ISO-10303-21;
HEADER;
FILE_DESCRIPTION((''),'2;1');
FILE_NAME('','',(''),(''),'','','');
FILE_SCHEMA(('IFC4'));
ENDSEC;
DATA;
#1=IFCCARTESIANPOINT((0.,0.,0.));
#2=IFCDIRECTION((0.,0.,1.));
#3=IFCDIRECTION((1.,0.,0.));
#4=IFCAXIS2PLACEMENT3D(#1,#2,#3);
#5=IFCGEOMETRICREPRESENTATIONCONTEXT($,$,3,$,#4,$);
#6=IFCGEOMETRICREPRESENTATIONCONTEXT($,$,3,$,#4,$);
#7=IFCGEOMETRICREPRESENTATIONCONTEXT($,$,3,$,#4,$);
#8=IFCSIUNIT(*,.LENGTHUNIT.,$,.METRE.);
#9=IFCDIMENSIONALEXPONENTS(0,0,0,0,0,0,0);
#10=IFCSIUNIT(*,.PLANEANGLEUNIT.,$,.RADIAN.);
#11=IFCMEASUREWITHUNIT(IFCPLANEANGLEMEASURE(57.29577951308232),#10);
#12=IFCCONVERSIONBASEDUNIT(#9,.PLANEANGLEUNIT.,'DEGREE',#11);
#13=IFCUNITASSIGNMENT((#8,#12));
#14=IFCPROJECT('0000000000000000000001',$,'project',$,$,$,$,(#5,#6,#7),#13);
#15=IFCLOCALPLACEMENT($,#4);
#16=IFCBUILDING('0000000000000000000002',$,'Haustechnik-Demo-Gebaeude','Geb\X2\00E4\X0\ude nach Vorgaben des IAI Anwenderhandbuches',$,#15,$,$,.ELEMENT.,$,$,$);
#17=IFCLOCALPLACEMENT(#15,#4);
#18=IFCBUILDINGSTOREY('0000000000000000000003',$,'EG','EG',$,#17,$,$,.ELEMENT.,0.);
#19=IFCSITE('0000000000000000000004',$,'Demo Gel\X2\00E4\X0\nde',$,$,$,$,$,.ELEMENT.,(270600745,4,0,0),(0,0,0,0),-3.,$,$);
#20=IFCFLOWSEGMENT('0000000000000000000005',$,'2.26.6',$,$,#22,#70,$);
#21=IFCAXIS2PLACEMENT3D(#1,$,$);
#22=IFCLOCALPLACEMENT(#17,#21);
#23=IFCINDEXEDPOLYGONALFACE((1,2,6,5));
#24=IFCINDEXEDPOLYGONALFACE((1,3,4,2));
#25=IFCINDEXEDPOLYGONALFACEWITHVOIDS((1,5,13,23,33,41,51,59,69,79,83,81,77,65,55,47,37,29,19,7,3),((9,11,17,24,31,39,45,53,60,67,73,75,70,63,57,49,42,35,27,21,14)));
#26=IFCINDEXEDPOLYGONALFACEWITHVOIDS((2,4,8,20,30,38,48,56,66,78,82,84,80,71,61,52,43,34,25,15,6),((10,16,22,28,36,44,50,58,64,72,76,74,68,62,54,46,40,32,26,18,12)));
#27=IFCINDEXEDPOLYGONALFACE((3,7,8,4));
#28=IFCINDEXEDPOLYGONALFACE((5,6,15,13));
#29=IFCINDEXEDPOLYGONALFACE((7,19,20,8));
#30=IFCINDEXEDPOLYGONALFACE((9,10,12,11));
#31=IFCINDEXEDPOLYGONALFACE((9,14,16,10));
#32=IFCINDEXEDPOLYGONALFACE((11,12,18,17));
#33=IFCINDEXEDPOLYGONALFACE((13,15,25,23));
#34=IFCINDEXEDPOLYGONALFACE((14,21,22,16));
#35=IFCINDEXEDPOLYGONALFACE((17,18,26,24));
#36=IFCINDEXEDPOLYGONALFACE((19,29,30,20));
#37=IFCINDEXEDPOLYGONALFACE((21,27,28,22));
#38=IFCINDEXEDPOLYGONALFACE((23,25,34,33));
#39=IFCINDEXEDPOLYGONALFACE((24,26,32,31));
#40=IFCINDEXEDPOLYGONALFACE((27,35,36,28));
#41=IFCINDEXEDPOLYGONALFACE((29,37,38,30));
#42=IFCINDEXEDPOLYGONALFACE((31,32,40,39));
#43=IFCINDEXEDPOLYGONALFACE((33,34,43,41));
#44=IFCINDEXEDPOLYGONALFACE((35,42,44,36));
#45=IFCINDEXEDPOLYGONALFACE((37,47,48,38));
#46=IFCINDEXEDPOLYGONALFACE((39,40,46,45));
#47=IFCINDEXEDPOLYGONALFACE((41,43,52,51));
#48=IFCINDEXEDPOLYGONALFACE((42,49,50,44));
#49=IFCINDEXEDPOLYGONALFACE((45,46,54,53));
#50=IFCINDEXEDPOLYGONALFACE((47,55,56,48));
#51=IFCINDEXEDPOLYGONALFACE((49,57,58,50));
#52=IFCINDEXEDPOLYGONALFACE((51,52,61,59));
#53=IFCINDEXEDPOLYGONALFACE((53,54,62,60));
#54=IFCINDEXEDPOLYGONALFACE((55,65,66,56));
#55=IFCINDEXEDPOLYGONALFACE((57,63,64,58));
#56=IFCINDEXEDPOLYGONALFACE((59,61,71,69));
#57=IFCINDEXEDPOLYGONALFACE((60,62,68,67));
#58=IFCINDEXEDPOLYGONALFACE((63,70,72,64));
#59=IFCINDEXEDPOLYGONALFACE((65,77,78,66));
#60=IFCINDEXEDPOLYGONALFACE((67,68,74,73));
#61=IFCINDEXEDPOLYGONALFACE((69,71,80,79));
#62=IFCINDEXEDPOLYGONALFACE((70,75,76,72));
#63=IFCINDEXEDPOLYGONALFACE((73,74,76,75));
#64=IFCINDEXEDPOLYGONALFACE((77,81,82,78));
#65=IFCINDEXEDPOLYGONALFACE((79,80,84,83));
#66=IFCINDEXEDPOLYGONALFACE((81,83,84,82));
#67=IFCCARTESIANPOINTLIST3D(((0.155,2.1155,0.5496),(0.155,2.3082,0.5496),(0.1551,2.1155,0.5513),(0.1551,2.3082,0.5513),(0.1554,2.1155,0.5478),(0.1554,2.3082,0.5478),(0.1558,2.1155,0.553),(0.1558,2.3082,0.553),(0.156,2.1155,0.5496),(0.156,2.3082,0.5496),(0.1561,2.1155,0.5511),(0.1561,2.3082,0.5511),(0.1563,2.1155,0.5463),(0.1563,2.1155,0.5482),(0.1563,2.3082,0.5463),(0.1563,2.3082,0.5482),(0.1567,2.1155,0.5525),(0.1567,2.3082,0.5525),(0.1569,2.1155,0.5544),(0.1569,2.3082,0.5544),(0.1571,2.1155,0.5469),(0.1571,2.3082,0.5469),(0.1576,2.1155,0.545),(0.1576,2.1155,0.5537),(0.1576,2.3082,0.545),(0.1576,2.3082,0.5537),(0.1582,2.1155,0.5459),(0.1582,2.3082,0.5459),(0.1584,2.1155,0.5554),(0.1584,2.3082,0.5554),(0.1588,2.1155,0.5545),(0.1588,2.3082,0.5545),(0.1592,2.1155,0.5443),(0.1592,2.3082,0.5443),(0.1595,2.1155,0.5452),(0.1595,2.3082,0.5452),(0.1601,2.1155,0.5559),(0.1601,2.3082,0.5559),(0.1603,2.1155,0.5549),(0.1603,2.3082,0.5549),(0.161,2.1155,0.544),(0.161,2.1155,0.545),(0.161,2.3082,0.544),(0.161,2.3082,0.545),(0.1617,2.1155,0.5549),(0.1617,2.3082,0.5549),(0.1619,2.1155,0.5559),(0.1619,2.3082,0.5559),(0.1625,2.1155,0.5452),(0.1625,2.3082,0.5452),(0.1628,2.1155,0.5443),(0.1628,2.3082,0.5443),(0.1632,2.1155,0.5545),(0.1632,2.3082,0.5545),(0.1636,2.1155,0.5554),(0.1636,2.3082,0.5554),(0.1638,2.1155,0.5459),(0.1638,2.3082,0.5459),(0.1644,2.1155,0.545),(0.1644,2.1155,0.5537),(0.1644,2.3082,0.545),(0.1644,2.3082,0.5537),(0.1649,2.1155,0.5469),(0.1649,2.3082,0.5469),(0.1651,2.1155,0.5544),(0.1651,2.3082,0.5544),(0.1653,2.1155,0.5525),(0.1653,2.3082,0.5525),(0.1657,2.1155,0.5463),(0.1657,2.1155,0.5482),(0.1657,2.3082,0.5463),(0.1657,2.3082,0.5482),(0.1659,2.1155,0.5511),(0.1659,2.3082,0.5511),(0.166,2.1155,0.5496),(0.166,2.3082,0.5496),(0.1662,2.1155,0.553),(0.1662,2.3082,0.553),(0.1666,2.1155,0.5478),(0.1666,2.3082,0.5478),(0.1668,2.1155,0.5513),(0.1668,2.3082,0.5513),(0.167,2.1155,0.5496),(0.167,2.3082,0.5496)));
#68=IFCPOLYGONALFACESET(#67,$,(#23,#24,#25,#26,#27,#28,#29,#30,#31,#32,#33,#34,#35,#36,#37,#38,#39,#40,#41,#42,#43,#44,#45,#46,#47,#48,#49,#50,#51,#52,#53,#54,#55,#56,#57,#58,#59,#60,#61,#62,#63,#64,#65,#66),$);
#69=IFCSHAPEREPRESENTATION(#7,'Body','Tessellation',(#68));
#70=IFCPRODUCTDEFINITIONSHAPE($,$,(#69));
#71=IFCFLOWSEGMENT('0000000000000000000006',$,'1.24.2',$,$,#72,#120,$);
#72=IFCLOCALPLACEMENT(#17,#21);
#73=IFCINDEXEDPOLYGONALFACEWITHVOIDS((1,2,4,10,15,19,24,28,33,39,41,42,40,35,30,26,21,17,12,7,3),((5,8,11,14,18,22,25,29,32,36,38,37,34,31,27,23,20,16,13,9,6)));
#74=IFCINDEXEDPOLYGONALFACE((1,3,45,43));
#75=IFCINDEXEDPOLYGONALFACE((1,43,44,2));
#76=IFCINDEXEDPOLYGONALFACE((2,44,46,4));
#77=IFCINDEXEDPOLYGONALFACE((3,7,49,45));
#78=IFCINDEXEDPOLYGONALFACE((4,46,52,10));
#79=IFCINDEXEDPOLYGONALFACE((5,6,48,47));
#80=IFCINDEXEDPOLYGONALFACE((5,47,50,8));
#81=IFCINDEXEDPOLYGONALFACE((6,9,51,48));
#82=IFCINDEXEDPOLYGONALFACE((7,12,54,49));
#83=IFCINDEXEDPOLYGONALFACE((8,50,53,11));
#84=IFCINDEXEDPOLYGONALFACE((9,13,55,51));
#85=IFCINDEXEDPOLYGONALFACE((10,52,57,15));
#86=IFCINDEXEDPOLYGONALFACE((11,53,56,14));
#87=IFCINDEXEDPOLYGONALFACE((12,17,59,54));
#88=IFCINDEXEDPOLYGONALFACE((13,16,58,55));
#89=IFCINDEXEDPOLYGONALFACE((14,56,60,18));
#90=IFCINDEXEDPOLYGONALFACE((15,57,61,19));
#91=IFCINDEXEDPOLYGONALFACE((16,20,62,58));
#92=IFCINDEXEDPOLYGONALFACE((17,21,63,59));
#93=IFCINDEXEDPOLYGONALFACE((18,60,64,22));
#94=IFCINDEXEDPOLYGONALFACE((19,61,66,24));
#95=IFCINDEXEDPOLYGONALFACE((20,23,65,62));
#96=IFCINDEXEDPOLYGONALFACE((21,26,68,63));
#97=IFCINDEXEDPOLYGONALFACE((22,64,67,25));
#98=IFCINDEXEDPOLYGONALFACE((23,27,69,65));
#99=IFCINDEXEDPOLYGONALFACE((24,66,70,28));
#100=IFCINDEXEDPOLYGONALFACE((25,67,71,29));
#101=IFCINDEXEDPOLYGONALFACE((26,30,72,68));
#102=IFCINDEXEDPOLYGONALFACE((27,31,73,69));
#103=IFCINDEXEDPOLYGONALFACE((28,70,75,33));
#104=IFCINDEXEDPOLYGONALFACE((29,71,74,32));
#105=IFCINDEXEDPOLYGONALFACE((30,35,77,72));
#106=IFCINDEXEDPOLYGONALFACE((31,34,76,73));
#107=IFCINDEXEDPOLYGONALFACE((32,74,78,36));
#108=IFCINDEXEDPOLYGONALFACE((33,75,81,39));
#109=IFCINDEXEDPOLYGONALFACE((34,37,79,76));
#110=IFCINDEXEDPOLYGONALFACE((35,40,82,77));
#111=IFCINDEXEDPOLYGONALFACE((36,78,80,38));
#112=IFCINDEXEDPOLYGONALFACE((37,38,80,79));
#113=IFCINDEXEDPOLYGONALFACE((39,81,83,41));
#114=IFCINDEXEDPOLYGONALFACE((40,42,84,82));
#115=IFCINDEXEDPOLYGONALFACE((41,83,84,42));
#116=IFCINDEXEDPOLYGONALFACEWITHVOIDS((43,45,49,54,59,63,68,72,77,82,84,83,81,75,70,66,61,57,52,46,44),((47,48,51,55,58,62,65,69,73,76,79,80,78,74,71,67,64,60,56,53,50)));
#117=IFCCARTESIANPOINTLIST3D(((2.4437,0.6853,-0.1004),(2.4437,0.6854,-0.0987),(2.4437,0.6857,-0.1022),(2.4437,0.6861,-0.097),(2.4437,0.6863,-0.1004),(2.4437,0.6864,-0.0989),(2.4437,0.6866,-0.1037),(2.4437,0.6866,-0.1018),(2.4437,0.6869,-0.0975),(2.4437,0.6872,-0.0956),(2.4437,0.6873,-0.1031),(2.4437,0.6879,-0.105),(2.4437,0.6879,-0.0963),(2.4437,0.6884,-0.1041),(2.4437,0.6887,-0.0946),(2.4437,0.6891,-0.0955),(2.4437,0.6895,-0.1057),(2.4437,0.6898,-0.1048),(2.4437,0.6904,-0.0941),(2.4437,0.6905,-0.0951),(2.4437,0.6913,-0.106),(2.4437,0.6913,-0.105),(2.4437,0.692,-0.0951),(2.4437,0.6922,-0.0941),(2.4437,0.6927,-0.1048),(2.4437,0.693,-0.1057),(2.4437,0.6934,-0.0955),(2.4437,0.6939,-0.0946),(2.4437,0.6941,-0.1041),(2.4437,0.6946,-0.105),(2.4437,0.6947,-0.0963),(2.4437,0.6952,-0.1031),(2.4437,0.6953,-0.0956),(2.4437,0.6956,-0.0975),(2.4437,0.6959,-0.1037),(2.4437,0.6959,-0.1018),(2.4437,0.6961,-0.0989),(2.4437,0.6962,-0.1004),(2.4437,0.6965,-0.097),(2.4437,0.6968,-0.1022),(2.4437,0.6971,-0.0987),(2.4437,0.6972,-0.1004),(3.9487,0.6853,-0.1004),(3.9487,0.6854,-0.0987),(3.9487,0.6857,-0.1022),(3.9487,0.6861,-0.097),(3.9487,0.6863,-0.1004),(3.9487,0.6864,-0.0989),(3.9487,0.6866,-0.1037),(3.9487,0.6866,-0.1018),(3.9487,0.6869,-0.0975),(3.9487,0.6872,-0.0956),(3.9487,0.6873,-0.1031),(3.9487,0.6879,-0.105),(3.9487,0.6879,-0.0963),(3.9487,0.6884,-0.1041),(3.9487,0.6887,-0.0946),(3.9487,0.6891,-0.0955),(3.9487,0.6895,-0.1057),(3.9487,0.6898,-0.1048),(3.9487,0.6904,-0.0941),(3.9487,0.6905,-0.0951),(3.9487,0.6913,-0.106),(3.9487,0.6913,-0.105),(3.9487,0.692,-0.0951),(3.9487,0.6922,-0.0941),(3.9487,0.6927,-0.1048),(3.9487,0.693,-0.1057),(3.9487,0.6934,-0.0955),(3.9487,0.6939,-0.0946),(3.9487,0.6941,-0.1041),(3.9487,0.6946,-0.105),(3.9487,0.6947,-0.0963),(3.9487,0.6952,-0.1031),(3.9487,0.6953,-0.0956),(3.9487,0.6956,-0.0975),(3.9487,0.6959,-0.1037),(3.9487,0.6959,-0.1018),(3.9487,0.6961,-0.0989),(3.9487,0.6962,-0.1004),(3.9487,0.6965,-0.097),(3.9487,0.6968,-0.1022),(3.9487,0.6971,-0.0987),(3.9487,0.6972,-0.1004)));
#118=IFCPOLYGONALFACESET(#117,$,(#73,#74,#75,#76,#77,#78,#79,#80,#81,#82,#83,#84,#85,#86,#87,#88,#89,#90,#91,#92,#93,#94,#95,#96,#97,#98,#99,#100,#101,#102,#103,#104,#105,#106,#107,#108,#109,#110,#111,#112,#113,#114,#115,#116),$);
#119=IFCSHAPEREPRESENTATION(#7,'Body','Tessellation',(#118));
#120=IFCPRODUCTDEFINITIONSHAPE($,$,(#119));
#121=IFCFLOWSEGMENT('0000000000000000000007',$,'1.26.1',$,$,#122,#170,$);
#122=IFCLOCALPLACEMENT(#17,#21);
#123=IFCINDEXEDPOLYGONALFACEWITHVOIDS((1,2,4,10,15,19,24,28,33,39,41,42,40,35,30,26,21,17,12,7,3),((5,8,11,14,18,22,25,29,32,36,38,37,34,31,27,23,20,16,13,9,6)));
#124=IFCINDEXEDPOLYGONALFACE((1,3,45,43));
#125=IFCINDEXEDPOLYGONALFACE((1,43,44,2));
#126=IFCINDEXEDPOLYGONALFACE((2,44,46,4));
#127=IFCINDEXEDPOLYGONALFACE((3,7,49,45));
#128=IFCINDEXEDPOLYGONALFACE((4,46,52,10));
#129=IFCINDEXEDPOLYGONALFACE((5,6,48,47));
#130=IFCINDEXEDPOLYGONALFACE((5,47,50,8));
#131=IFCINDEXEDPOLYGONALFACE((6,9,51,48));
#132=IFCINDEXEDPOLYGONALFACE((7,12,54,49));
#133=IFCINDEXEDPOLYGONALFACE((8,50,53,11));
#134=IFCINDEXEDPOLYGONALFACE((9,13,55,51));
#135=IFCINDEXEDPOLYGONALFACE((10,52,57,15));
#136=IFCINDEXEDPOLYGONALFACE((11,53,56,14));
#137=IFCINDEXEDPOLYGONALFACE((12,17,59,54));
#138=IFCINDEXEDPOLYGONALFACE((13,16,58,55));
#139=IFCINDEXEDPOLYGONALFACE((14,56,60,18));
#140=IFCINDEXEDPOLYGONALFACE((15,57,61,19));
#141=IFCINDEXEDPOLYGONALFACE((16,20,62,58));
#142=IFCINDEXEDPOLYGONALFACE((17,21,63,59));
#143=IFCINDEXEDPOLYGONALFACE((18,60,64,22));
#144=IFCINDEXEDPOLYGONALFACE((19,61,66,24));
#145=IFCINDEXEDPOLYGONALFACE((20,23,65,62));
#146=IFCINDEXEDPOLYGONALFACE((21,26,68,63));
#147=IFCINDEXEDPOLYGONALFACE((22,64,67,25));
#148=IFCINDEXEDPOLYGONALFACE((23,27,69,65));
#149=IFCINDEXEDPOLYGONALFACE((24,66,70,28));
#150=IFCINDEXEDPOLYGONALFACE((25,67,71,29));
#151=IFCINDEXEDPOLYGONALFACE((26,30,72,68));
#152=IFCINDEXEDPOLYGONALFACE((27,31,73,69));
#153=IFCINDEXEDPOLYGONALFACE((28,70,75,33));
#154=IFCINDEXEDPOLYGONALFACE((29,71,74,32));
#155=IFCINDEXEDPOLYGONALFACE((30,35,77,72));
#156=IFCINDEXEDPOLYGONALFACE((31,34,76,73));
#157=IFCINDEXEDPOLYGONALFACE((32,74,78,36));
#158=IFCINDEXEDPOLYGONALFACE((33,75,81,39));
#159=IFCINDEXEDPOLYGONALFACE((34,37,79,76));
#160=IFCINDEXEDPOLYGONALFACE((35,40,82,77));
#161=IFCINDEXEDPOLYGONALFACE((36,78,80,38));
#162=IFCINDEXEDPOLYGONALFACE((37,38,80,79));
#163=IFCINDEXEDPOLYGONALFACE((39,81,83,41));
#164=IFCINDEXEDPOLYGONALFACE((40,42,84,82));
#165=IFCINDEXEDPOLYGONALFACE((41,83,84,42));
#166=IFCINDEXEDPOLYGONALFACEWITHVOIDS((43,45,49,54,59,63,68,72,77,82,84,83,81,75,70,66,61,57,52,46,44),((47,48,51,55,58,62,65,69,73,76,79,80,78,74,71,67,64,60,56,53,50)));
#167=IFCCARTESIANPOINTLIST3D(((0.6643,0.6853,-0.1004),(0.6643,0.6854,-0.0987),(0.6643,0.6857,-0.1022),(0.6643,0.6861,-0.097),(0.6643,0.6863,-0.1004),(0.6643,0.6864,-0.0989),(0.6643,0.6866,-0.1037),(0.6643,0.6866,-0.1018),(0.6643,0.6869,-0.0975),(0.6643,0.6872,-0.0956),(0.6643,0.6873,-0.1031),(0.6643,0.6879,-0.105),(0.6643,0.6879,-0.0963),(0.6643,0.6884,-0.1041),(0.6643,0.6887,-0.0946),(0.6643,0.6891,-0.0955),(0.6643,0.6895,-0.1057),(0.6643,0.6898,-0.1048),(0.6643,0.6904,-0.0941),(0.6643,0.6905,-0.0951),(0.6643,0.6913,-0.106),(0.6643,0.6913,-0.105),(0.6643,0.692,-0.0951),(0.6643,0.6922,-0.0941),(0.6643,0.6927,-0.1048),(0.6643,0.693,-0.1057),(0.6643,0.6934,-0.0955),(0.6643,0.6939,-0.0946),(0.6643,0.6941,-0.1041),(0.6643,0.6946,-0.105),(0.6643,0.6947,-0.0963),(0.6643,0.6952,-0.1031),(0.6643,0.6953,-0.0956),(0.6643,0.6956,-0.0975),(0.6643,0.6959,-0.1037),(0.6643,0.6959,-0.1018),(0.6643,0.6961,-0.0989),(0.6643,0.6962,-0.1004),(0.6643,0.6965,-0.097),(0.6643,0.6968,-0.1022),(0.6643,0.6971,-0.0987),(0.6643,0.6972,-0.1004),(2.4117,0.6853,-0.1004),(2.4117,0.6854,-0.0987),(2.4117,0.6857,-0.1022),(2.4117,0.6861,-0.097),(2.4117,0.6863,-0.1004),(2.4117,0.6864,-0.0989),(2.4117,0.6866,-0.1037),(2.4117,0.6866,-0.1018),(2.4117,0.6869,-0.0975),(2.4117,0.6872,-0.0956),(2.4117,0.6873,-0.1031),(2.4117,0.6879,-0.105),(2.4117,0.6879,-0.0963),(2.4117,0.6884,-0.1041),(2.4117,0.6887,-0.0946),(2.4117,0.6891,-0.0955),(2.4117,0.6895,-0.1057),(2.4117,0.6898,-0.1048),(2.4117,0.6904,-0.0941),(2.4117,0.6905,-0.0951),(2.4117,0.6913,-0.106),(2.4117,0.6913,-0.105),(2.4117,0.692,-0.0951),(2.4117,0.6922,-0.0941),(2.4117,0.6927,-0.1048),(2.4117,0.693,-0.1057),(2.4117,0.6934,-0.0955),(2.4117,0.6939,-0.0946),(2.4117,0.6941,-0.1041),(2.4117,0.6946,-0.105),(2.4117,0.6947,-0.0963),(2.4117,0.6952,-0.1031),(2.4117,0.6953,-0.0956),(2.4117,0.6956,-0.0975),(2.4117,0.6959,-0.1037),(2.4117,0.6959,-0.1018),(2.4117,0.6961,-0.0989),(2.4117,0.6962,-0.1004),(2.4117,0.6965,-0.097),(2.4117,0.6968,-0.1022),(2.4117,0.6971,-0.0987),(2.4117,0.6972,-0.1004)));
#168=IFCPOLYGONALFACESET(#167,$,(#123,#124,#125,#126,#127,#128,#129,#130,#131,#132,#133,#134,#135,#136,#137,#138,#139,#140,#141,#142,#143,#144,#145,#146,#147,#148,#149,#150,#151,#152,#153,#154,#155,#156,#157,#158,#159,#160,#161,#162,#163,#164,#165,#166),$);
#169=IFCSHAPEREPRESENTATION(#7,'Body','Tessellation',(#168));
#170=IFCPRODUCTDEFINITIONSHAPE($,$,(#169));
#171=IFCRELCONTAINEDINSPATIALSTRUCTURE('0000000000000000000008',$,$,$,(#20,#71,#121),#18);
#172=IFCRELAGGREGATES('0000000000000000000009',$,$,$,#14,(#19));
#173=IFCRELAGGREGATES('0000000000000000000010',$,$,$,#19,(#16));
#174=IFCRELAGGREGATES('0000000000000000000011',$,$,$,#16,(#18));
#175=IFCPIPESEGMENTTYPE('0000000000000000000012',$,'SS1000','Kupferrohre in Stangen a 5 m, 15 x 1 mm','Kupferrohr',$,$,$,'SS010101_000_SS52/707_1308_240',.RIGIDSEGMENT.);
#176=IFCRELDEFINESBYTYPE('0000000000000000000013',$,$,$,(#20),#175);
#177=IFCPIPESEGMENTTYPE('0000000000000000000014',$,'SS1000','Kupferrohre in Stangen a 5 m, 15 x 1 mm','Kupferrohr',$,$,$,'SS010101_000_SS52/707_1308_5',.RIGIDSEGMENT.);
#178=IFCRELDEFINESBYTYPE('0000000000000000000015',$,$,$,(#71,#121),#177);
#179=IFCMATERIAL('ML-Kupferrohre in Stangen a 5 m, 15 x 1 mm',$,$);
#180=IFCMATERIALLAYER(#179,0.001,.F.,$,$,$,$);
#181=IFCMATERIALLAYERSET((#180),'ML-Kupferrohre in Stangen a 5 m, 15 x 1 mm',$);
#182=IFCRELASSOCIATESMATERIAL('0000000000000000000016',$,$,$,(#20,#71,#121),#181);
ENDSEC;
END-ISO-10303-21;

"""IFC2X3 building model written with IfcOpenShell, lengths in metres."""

from ifc_helpers import new_model, entity, si_unit, converted_unit, frame, origin_with_axes, origin_2d_with_axis, place, context, project, spatial, hollow_circle, extrude, material, layer, layer_set, layer_usage, type_object, element, save


model = new_model("IFC2X3")

# Units and contexts
context_of_model_1 = context(None, 3, world=origin_with_axes())
context_of_model_2 = context(None, 3, world=origin_with_axes())
context_of_model_3 = context(None, 3, world=origin_with_axes())
ifc_project = project(units=[si_unit("LENGTHUNIT", "METRE"), converted_unit("PLANEANGLEUNIT", "DEGREE", entity("IfcPlaneAngleMeasure", 57.29577951308232), si_unit("PLANEANGLEUNIT", "RADIAN"), dimensions=[0, 0, 0, 0, 0, 0, 0])], contexts=[context_of_model_1, context_of_model_2, context_of_model_3])

# Site, building, storey
site = spatial("IfcSite", under=ifc_project, Name="Demo Gelände", CompositionType="ELEMENT", RefLatitude=(270600745, 4, 0, 0), RefLongitude=(0, 0, 0, 0), RefElevation=-3.0)
building_placement = place(None, origin_with_axes())
building = spatial("IfcBuilding", under=site, at=building_placement, Name="Haustechnik-Demo-Gebaeude", Description="Gebäude nach Vorgaben des IAI Anwenderhandbuches", CompositionType="ELEMENT")
storey_placement = place(building_placement, origin_with_axes())
storey = spatial("IfcBuildingStorey", under=building, at=storey_placement, Name="EG", Description="EG", CompositionType="ELEMENT", Elevation=0.0)

# Flow segments
ifc_material = material(Name="ML-Kupferrohre in Stangen a 5 m, 15 x 1 mm")
ifc_layer = layer(ifc_material, 0.001, ventilated=False)
ifc_layer_set = layer_set([ifc_layer], Name="ML-Kupferrohre in Stangen a 5 m, 15 x 1 mm")
ifc_layer_usage = layer_usage(ifc_layer_set, "AXIS2", "POSITIVE", 0.0)
pipe_segment_type_1 = type_object("IfcPipeSegmentType", Name="SS1000", Description="Kupferrohre in Stangen a 5 m, 15 x 1 mm", ApplicableOccurrence="Kupferrohr", ElementType="SS010101_000_SS52/707_1308_240", PredefinedType="RIGIDSEGMENT")
flow_segment_1_placement = place(storey_placement, frame((0.161, 2.3082, 0.55), z_axis=(0.0, -1.0, 0.0), x_axis=(0.0, 0.0, -1.0)))
element("IfcFlowSegment", 1, at=flow_segment_1_placement, inside=storey, type_object=pipe_segment_type_1, material=ifc_layer_usage, Name="2.26.6", context=context_of_model_3, shape_type="SweptSolid", body=[
    extrude(hollow_circle(Radius=0.006, WallThickness=0.001, at=origin_2d_with_axis()), origin_with_axes(), (0.0, 0.0, 1.0), 0.1927),
])
pipe_segment_type_2 = type_object("IfcPipeSegmentType", Name="SS1000", Description="Kupferrohre in Stangen a 5 m, 15 x 1 mm", ApplicableOccurrence="Kupferrohr", ElementType="SS010101_000_SS52/707_1308_5", PredefinedType="RIGIDSEGMENT")
flow_segment_2_placement = place(storey_placement, frame((3.9487, 0.6913, -0.1), z_axis=(-1.0, 0.0, 0.0), x_axis=(0.0, 0.0, -1.0)))
element("IfcFlowSegment", 2, at=flow_segment_2_placement, inside=storey, type_object=pipe_segment_type_2, material=ifc_layer_usage, Name="1.24.2", context=context_of_model_3, shape_type="SweptSolid", body=[
    extrude(hollow_circle(Radius=0.006, WallThickness=0.001, at=origin_2d_with_axis()), origin_with_axes(), (0.0, 0.0, 1.0), 1.505),
])
flow_segment_3_placement = place(storey_placement, frame((2.4117, 0.6913, -0.1), z_axis=(-1.0, 0.0, 0.0), x_axis=(0.0, 0.0, -1.0)))
element("IfcFlowSegment", 3, at=flow_segment_3_placement, inside=storey, type_object=pipe_segment_type_2, material=ifc_layer_usage, Name="1.26.1", context=context_of_model_3, shape_type="SweptSolid", body=[
    extrude(hollow_circle(Radius=0.006, WallThickness=0.001, at=origin_2d_with_axis()), origin_with_axes(), (0.0, 0.0, 1.0), 1.7474),
])

save(model, "model.ifc")
